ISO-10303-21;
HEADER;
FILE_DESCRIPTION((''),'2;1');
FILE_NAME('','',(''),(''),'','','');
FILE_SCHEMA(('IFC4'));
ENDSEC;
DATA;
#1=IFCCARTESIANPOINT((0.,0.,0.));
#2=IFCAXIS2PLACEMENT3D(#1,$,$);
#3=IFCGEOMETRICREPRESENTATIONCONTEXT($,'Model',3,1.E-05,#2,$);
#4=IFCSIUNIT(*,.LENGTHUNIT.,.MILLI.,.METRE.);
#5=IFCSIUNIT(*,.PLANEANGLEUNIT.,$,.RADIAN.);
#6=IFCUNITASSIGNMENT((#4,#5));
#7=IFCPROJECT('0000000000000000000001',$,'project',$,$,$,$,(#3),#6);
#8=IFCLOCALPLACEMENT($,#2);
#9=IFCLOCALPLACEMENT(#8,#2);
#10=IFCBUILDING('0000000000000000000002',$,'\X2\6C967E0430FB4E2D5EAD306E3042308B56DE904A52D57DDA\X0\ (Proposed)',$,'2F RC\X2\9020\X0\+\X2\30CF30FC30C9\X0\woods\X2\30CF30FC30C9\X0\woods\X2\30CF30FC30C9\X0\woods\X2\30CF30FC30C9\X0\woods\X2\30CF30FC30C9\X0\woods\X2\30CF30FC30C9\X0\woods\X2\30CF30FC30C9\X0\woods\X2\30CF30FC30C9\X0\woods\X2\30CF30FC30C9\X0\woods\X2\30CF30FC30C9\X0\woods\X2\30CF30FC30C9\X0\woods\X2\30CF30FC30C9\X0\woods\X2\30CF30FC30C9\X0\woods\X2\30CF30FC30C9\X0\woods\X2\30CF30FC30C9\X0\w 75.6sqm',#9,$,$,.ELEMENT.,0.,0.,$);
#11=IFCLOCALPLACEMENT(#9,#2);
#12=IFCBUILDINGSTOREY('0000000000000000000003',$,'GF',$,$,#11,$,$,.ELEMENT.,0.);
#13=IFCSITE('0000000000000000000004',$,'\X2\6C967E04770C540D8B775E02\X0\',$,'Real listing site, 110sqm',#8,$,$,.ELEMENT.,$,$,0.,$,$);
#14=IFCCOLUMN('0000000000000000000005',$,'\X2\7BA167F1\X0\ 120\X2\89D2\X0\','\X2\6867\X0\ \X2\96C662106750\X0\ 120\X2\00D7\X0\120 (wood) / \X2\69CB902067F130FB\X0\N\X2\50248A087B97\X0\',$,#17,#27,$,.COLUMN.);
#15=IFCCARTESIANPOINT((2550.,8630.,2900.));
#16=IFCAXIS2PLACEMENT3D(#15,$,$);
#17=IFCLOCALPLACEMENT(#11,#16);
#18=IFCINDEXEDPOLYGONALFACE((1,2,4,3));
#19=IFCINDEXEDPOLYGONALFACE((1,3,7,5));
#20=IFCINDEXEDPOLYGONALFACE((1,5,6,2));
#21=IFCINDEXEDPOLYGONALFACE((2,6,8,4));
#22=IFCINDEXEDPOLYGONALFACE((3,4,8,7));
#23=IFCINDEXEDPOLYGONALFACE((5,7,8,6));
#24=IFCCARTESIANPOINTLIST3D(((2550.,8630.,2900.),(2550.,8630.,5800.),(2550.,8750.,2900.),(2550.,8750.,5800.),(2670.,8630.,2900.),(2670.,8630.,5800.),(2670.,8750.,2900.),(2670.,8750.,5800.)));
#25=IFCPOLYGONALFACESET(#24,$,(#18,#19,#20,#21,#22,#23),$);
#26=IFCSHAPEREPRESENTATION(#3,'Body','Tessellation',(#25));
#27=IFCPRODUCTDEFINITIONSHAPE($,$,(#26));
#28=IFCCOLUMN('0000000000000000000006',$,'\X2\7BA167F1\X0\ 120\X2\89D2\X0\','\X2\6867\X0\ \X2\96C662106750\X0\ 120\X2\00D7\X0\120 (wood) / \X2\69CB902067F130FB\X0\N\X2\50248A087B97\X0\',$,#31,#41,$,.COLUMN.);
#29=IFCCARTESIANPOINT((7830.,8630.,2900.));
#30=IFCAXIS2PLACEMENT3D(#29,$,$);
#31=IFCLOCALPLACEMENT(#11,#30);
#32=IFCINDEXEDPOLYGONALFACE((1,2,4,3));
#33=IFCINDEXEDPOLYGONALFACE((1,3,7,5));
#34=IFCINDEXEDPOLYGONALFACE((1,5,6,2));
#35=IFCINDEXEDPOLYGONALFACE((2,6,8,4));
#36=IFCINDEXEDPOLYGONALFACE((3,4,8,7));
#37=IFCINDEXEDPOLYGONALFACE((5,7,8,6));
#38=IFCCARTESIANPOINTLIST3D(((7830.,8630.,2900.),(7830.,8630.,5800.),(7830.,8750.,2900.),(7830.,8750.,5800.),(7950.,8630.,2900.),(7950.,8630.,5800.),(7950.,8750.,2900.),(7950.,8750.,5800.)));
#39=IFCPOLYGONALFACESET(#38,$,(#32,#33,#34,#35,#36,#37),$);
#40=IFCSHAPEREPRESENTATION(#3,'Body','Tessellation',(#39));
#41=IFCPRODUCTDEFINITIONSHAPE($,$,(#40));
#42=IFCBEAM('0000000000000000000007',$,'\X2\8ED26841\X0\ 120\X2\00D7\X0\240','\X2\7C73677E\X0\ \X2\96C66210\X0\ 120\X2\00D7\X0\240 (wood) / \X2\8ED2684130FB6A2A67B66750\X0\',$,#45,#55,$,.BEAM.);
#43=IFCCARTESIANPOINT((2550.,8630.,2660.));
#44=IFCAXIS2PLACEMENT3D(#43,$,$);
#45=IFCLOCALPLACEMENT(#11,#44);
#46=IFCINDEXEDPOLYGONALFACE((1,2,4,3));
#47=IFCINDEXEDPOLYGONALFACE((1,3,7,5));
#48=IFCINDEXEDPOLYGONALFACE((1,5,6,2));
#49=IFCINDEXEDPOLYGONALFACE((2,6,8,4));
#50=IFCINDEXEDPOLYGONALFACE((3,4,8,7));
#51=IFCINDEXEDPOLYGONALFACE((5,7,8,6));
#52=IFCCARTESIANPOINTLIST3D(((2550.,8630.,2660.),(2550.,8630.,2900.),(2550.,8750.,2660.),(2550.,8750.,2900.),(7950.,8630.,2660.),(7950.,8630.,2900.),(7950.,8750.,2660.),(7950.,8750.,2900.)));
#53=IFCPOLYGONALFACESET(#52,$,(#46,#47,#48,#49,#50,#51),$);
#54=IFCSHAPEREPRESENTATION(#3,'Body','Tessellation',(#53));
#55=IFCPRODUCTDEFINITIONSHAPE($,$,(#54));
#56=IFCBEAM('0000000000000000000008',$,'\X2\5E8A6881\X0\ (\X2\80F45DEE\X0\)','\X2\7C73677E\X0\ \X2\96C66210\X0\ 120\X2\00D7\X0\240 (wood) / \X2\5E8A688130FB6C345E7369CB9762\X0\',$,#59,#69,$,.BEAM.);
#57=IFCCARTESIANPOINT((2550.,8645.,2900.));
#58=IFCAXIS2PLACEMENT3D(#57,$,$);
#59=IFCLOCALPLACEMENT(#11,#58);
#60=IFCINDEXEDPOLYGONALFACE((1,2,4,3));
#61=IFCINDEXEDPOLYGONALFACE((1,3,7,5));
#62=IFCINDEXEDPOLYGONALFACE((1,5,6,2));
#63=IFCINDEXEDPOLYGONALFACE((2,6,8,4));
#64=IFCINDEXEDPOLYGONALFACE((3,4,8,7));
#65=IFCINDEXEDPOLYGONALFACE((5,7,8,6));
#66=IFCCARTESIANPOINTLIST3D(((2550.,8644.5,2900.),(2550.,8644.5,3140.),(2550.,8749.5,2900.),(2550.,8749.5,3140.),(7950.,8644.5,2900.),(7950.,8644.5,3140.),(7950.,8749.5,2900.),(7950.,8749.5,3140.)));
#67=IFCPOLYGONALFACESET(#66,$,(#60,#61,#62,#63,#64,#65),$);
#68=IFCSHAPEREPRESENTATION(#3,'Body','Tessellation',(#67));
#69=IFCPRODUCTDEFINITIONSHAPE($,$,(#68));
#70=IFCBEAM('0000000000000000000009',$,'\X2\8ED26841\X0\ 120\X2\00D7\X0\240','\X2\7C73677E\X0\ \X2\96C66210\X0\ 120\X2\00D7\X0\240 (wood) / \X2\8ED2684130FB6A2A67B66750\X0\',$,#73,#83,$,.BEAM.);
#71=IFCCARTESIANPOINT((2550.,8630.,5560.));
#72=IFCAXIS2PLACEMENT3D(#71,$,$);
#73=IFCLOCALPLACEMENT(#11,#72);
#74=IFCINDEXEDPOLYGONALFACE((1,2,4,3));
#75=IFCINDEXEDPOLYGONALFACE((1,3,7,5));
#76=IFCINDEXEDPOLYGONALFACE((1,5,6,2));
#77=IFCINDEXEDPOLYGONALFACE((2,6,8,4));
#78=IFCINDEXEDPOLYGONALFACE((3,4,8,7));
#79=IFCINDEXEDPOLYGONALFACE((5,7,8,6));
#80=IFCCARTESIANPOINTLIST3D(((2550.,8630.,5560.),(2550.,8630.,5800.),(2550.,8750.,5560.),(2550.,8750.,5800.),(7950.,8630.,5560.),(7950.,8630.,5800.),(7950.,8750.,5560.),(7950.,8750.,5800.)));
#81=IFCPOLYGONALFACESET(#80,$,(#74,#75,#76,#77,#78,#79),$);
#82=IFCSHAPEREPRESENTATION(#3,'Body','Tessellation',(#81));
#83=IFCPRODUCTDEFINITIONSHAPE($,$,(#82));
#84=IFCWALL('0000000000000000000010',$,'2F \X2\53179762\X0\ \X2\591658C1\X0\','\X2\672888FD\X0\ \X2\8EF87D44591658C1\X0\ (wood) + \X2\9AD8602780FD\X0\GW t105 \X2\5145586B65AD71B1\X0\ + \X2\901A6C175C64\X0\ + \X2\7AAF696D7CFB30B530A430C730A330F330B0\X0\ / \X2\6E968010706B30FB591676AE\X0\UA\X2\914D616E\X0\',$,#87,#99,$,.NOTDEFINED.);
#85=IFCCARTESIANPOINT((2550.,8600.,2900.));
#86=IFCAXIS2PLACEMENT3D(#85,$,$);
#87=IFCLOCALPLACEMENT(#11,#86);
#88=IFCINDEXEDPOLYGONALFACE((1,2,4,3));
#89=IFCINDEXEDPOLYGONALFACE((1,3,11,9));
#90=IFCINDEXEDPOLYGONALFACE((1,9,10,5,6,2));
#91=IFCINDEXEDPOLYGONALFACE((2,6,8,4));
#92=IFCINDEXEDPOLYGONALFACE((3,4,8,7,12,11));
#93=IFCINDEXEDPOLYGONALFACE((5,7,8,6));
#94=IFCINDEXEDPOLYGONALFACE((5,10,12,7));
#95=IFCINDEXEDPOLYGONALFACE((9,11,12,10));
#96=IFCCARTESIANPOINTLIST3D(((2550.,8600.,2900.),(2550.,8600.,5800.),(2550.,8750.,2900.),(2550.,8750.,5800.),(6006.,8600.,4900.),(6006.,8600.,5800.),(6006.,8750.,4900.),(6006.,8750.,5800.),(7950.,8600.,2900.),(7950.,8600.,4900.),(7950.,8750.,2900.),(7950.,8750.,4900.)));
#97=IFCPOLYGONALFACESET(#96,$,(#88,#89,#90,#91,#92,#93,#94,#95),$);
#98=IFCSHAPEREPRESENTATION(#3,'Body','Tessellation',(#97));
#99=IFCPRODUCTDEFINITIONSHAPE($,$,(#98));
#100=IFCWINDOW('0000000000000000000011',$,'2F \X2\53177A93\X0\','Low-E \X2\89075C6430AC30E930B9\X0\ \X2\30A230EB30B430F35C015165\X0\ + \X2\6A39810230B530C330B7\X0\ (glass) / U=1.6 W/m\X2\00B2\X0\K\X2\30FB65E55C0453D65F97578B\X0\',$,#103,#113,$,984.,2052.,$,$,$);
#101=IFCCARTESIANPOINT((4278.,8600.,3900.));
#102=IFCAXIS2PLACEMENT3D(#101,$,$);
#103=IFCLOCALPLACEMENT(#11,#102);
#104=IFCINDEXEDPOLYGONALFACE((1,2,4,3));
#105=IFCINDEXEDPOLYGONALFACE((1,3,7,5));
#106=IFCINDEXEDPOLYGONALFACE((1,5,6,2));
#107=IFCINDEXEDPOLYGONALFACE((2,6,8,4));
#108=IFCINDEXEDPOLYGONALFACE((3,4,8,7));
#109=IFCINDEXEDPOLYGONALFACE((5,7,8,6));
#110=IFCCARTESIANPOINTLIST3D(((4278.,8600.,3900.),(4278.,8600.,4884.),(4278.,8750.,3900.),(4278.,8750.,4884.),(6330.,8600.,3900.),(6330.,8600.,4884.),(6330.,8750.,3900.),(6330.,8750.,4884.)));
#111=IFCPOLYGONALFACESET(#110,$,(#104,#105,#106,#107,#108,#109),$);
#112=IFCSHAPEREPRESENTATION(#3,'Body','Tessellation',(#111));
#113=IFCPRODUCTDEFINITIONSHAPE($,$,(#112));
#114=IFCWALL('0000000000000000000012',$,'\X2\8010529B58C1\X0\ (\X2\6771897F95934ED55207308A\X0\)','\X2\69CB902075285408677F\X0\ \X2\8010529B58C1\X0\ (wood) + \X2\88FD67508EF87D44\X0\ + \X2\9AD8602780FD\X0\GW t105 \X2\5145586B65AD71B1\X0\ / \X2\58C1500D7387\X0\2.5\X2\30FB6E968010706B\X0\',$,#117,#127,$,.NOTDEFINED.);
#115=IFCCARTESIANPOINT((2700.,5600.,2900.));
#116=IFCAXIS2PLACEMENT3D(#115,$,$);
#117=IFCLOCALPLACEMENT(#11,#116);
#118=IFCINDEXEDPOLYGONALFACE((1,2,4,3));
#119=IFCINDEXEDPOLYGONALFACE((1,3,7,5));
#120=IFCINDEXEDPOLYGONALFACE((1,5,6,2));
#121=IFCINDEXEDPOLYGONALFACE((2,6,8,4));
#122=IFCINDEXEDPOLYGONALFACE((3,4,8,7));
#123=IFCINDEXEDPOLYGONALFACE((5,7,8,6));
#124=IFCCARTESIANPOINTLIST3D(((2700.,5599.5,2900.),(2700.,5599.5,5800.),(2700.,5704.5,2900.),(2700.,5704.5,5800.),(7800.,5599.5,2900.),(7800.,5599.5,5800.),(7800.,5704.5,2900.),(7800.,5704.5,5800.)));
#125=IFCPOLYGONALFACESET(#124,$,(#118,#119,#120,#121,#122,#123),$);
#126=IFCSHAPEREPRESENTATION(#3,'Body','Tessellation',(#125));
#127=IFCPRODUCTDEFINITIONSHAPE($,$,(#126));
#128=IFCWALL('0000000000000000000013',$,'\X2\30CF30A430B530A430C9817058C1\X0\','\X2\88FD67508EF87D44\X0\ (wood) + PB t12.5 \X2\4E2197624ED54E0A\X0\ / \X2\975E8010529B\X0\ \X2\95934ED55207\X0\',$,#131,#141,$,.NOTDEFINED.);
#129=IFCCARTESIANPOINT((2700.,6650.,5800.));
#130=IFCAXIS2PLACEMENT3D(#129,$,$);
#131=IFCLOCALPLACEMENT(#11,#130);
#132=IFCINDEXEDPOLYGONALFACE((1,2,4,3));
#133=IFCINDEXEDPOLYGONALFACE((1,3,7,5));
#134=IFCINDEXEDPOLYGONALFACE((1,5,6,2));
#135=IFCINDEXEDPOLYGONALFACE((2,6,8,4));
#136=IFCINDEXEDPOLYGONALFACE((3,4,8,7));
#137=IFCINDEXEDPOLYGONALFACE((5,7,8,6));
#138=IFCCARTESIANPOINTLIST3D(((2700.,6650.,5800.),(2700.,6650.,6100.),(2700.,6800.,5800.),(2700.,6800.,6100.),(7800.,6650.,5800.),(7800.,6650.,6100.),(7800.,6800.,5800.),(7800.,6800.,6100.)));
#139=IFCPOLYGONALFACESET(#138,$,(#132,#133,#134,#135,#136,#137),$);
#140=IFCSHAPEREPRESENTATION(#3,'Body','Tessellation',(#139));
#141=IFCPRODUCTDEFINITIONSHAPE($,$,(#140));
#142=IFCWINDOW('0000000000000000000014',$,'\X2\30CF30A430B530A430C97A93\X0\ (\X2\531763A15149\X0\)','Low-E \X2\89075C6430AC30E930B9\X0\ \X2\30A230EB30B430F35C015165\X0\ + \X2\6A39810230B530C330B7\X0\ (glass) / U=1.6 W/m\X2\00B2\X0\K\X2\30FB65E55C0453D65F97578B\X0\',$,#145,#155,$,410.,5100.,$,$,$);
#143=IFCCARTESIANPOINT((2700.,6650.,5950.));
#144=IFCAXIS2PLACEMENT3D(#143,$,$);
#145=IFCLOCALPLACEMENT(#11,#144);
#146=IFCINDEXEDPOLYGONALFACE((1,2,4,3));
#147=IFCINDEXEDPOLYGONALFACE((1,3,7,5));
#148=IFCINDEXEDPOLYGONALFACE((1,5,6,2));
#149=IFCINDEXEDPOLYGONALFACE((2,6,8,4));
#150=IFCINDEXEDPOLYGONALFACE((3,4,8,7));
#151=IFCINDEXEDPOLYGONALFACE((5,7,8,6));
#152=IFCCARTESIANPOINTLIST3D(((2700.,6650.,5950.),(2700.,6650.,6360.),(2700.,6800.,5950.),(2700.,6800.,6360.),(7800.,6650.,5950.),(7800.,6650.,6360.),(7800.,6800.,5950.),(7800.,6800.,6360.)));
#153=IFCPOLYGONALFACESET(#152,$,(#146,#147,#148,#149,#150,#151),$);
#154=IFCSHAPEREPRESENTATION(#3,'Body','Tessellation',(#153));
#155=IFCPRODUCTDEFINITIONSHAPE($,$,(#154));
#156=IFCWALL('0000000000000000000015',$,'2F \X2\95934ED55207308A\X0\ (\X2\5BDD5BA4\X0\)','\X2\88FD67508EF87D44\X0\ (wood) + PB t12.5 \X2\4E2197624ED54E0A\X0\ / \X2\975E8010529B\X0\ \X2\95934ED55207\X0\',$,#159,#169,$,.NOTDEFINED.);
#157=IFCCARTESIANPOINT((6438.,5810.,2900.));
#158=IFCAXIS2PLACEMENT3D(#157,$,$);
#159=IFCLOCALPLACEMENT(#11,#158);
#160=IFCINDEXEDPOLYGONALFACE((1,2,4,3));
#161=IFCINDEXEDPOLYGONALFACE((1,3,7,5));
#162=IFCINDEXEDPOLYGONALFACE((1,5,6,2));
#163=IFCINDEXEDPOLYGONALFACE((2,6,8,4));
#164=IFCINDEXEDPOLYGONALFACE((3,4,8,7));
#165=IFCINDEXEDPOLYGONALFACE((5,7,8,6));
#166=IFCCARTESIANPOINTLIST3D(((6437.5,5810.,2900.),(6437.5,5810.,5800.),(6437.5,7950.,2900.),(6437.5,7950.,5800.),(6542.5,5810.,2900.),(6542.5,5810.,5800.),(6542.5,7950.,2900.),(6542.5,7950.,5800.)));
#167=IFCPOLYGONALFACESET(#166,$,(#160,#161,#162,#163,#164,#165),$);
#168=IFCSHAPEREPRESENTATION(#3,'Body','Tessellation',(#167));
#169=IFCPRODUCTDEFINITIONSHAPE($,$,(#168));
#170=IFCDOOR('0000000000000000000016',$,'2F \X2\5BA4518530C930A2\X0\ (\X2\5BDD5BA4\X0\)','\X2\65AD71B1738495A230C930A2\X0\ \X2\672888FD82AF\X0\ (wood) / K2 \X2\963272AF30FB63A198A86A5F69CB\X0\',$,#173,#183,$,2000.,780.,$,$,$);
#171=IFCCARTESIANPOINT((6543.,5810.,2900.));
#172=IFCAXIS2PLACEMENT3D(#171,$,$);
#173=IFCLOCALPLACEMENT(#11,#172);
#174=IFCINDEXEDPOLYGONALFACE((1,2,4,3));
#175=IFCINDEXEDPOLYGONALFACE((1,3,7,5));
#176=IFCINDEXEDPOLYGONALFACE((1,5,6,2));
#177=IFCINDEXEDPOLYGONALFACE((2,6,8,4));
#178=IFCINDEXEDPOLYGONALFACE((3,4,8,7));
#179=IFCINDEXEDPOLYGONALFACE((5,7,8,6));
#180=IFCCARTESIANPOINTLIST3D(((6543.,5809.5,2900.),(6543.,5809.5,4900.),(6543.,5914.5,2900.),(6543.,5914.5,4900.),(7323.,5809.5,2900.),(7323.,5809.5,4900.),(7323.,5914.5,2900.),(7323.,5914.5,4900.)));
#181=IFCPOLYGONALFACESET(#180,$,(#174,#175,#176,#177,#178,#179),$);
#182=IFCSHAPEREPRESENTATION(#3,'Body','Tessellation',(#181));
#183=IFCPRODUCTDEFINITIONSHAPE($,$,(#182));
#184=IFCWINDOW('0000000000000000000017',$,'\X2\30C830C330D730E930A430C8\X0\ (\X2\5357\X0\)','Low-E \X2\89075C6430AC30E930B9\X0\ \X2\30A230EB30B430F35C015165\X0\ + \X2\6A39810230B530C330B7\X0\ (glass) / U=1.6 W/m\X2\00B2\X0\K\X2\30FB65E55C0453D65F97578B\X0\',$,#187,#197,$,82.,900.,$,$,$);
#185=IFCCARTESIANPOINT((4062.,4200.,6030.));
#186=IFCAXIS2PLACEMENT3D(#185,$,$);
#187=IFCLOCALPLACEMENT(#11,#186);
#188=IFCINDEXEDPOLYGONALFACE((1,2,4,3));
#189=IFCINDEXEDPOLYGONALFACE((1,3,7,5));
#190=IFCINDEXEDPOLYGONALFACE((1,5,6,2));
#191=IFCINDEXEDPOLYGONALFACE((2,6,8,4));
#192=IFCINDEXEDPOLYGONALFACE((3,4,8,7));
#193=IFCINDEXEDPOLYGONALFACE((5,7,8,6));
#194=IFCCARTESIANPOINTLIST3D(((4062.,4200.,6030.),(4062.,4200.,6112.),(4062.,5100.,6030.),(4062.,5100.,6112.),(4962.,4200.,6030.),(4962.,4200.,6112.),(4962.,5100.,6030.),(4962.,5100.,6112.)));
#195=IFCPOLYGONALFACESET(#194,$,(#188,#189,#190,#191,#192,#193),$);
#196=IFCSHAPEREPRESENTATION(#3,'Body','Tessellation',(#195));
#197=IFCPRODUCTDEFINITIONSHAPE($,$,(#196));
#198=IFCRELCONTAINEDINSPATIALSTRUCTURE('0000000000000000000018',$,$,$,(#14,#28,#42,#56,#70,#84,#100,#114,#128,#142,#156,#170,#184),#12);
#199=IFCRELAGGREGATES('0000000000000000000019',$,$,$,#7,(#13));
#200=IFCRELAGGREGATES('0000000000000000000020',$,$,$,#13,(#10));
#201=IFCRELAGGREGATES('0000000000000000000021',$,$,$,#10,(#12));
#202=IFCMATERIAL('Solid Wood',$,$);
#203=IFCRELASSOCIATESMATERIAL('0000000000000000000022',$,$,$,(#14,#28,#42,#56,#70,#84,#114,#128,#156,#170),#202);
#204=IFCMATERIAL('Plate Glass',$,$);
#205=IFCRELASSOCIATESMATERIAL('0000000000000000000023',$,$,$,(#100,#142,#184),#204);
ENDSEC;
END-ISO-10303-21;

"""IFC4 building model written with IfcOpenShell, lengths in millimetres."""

from ifc_helpers import new_model, si_unit, frame, frame_2d, origin, place, context, project, spatial, rectangle, extrude, material, element, fill, save


model = new_model("IFC4")

# Units and contexts
model_context = context("Model", 3, precision=1e-05, world=origin())
ifc_project = project(units=[si_unit("LENGTHUNIT", "METRE", prefix="MILLI"), si_unit("PLANEANGLEUNIT", "RADIAN")], contexts=[model_context])

# Site, building, storey
site_placement = place(None, origin())
site = spatial("IfcSite", under=ifc_project, at=site_placement, Name="沖縄県名護市", ObjectType="Real listing site, 110sqm", CompositionType="ELEMENT", RefElevation=0.0)
building_placement = place(site_placement, origin())
building = spatial("IfcBuilding", under=site, at=building_placement, Name="沖縄・中庭のある回遊動線 (Proposed)", ObjectType="2F RC造+ハードwoodsハードwoodsハードwoodsハードwoodsハードwoodsハードwoodsハードwoodsハードwoodsハードwoodsハードwoodsハードwoodsハードwoodsハードwoodsハードwoodsハードw 75.6sqm", CompositionType="ELEMENT", ElevationOfRefHeight=0.0, ElevationOfTerrain=0.0)
storey_placement = place(building_placement, origin())
storey = spatial("IfcBuildingStorey", under=building, at=storey_placement, Name="GF", CompositionType="ELEMENT", Elevation=0.0)

# Columns
ifc_material_1 = material(Name="Solid Wood")
column_1_placement = place(storey_placement, frame((2550.0, 8630.0, 2900.0)))
element("IfcColumn", 1, at=column_1_placement, inside=storey, material=ifc_material_1, Name="管柱 120角", Description="桧 集成材 120×120 (wood) / 構造柱・N値計算", PredefinedType="COLUMN", context=model_context, shape_type="SweptSolid", body=[
    extrude(rectangle(XDim=120.0, YDim=120.0, at=frame_2d((60.0, 60.0))), frame((2550.0, 8630.0, 2900.0)), (0.0, 0.0, 1.0), 2900.0),
])
column_2_placement = place(storey_placement, frame((7830.0, 8630.0, 2900.0)))
element("IfcColumn", 2, at=column_2_placement, inside=storey, material=ifc_material_1, Name="管柱 120角", Description="桧 集成材 120×120 (wood) / 構造柱・N値計算", PredefinedType="COLUMN", context=model_context, shape_type="SweptSolid", body=[
    extrude(rectangle(XDim=120.0, YDim=120.0, at=frame_2d((60.0, 60.0))), frame((7830.0, 8630.0, 2900.0)), (0.0, 0.0, 1.0), 2900.0),
])

# Beams
beam_1_placement = place(storey_placement, frame((2550.0, 8630.0, 2660.0)))
element("IfcBeam", 3, at=beam_1_placement, inside=storey, material=ifc_material_1, Name="軒桁 120×240", Description="米松 集成 120×240 (wood) / 軒桁・横架材", PredefinedType="BEAM", context=model_context, shape_type="SweptSolid", body=[
    extrude(rectangle(XDim=5400.0, YDim=120.0, at=frame_2d((2700.0, 60.0))), frame((2550.0, 8630.0, 2660.0)), (0.0, 0.0, 1.0), 240.0),
])
beam_2_placement = place(storey_placement, frame((2550.0, 8645.0, 2900.0)))
element("IfcBeam", 4, at=beam_2_placement, inside=storey, material=ifc_material_1, Name="床梁 (胴差)", Description="米松 集成 120×240 (wood) / 床梁・水平構面", PredefinedType="BEAM", context=model_context, shape_type="SweptSolid", body=[
    extrude(rectangle(XDim=5400.0, YDim=105.0, at=frame_2d((2700.0, 52.0))), frame((2550.0, 8645.0, 2900.0)), (0.0, 0.0, 1.0), 240.0),
])
beam_3_placement = place(storey_placement, frame((2550.0, 8630.0, 5560.0)))
element("IfcBeam", 5, at=beam_3_placement, inside=storey, material=ifc_material_1, Name="軒桁 120×240", Description="米松 集成 120×240 (wood) / 軒桁・横架材", PredefinedType="BEAM", context=model_context, shape_type="SweptSolid", body=[
    extrude(rectangle(XDim=5400.0, YDim=120.0, at=frame_2d((2700.0, 60.0))), frame((2550.0, 8630.0, 5560.0)), (0.0, 0.0, 1.0), 240.0),
])

# Wall, opening, window
wall_1_placement = place(storey_placement, frame((2550.0, 8600.0, 2900.0)))
wall_1 = element("IfcWall", 6, at=wall_1_placement, inside=storey, material=ifc_material_1, Name="2F 北面 外壁", Description="木製 軸組外壁 (wood) + 高性能GW t105 充填断熱 + 通気層 + 窯業系サイディング / 準耐火・外皮UA配慮", PredefinedType="NOTDEFINED", context=model_context, shape_type="SweptSolid", body=[
    extrude(rectangle(XDim=5400.0, YDim=150.0, at=frame_2d((2700.0, 75.0))), frame((2550.0, 8600.0, 2900.0)), (0.0, 0.0, 1.0), 2900.0),
])
opening_1_placement = place(storey_placement, frame((4278.0, 8600.0, 3900.0)))
opening_1 = element("IfcOpeningElement", 7, at=opening_1_placement, cuts=wall_1, PredefinedType="NOTDEFINED", context=model_context, shape_type="SweptSolid", body=[
    extrude(rectangle(XDim=2052.0, YDim=150.0, at=frame_2d((1026.0, 75.0))), frame((4278.0, 8600.0, 3900.0)), (0.0, 0.0, 1.0), 984.0),
])
ifc_material_2 = material(Name="Plate Glass")
window_1_placement = place(storey_placement, frame((4278.0, 8600.0, 3900.0)))
window_1 = element("IfcWindow", 8, at=window_1_placement, inside=storey, material=ifc_material_2, Name="2F 北窓", Description="Low-E 複層ガラス アルゴン封入 + 樹脂サッシ (glass) / U=1.6 W/m²K・日射取得型", OverallHeight=984.0, OverallWidth=2052.0, context=model_context, shape_type="SweptSolid", body=[
    extrude(rectangle(XDim=2052.0, YDim=150.0, at=frame_2d((1026.0, 75.0))), frame((4278.0, 8600.0, 3900.0)), (0.0, 0.0, 1.0), 984.0),
])
fill(opening_1, window_1)

# Wall
wall_2_placement = place(storey_placement, frame((2700.0, 5600.0, 2900.0)))
element("IfcWall", 9, at=wall_2_placement, inside=storey, material=ifc_material_1, Name="耐力壁 (東西間仕切り)", Description="構造用合板 耐力壁 (wood) + 製材軸組 + 高性能GW t105 充填断熱 / 壁倍率2.5・準耐火", PredefinedType="NOTDEFINED", context=model_context, shape_type="SweptSolid", body=[
    extrude(rectangle(XDim=5100.0, YDim=105.0, at=frame_2d((2550.0, 52.0))), frame((2700.0, 5600.0, 2900.0)), (0.0, 0.0, 1.0), 2900.0),
])

# Wall, opening, window
wall_3_placement = place(storey_placement, frame((2700.0, 6650.0, 5800.0)))
wall_3 = element("IfcWall", 10, at=wall_3_placement, inside=storey, material=ifc_material_1, Name="ハイサイド腰壁", Description="製材軸組 (wood) + PB t12.5 両面仕上 / 非耐力 間仕切", PredefinedType="NOTDEFINED", context=model_context, shape_type="SweptSolid", body=[
    extrude(rectangle(XDim=5100.0, YDim=150.0, at=frame_2d((2550.0, 75.0))), frame((2700.0, 6650.0, 5800.0)), (0.0, 0.0, 1.0), 700.0),
])
opening_2_placement = place(storey_placement, frame((2700.0, 6650.0, 5950.0)))
opening_2 = element("IfcOpeningElement", 11, at=opening_2_placement, cuts=wall_3, PredefinedType="NOTDEFINED", context=model_context, shape_type="SweptSolid", body=[
    extrude(rectangle(XDim=5100.0, YDim=150.0, at=frame_2d((2550.0, 75.0))), frame((2700.0, 6650.0, 5950.0)), (0.0, 0.0, 1.0), 410.0),
])
window_2_placement = place(storey_placement, frame((2700.0, 6650.0, 5950.0)))
window_2 = element("IfcWindow", 12, at=window_2_placement, inside=storey, material=ifc_material_2, Name="ハイサイド窓 (北採光)", Description="Low-E 複層ガラス アルゴン封入 + 樹脂サッシ (glass) / U=1.6 W/m²K・日射取得型", OverallHeight=410.0, OverallWidth=5100.0, context=model_context, shape_type="SweptSolid", body=[
    extrude(rectangle(XDim=5100.0, YDim=150.0, at=frame_2d((2550.0, 75.0))), frame((2700.0, 6650.0, 5950.0)), (0.0, 0.0, 1.0), 410.0),
])
fill(opening_2, window_2)

# Wall
wall_4_placement = place(storey_placement, frame((6438.0, 5810.0, 2900.0)))
element("IfcWall", 13, at=wall_4_placement, inside=storey, material=ifc_material_1, Name="2F 間仕切り (寝室)", Description="製材軸組 (wood) + PB t12.5 両面仕上 / 非耐力 間仕切", PredefinedType="NOTDEFINED", context=model_context, shape_type="SweptSolid", body=[
    extrude(rectangle(XDim=105.0, YDim=2140.0, at=frame_2d((52.0, 1070.0))), frame((6438.0, 5810.0, 2900.0)), (0.0, 0.0, 1.0), 2900.0),
])

# Door
door_placement = place(storey_placement, frame((6543.0, 5810.0, 2900.0)))
element("IfcDoor", 14, at=door_placement, inside=storey, material=ifc_material_1, Name="2F 室内ドア (寝室)", Description="断熱玄関ドア 木製芯 (wood) / K2 防犯・採風機構", OverallHeight=2000.0, OverallWidth=780.0, context=model_context, shape_type="SweptSolid", body=[
    extrude(rectangle(XDim=780.0, YDim=105.0, at=frame_2d((390.0, 52.0))), frame((6543.0, 5810.0, 2900.0)), (0.0, 0.0, 1.0), 2000.0),
])

# Window
window_3_placement = place(storey_placement, frame((4062.0, 4200.0, 6030.0)))
element("IfcWindow", 15, at=window_3_placement, inside=storey, material=ifc_material_2, Name="トップライト (南)", Description="Low-E 複層ガラス アルゴン封入 + 樹脂サッシ (glass) / U=1.6 W/m²K・日射取得型", OverallHeight=82.0, OverallWidth=900.0, context=model_context, shape_type="SweptSolid", body=[
    extrude(rectangle(XDim=900.0, YDim=900.0, at=frame_2d((450.0, 450.0))), frame((4062.0, 4200.0, 6030.0)), (0.0, 0.0, 1.0), 82.0),
])

save(model, "model.ifc")
